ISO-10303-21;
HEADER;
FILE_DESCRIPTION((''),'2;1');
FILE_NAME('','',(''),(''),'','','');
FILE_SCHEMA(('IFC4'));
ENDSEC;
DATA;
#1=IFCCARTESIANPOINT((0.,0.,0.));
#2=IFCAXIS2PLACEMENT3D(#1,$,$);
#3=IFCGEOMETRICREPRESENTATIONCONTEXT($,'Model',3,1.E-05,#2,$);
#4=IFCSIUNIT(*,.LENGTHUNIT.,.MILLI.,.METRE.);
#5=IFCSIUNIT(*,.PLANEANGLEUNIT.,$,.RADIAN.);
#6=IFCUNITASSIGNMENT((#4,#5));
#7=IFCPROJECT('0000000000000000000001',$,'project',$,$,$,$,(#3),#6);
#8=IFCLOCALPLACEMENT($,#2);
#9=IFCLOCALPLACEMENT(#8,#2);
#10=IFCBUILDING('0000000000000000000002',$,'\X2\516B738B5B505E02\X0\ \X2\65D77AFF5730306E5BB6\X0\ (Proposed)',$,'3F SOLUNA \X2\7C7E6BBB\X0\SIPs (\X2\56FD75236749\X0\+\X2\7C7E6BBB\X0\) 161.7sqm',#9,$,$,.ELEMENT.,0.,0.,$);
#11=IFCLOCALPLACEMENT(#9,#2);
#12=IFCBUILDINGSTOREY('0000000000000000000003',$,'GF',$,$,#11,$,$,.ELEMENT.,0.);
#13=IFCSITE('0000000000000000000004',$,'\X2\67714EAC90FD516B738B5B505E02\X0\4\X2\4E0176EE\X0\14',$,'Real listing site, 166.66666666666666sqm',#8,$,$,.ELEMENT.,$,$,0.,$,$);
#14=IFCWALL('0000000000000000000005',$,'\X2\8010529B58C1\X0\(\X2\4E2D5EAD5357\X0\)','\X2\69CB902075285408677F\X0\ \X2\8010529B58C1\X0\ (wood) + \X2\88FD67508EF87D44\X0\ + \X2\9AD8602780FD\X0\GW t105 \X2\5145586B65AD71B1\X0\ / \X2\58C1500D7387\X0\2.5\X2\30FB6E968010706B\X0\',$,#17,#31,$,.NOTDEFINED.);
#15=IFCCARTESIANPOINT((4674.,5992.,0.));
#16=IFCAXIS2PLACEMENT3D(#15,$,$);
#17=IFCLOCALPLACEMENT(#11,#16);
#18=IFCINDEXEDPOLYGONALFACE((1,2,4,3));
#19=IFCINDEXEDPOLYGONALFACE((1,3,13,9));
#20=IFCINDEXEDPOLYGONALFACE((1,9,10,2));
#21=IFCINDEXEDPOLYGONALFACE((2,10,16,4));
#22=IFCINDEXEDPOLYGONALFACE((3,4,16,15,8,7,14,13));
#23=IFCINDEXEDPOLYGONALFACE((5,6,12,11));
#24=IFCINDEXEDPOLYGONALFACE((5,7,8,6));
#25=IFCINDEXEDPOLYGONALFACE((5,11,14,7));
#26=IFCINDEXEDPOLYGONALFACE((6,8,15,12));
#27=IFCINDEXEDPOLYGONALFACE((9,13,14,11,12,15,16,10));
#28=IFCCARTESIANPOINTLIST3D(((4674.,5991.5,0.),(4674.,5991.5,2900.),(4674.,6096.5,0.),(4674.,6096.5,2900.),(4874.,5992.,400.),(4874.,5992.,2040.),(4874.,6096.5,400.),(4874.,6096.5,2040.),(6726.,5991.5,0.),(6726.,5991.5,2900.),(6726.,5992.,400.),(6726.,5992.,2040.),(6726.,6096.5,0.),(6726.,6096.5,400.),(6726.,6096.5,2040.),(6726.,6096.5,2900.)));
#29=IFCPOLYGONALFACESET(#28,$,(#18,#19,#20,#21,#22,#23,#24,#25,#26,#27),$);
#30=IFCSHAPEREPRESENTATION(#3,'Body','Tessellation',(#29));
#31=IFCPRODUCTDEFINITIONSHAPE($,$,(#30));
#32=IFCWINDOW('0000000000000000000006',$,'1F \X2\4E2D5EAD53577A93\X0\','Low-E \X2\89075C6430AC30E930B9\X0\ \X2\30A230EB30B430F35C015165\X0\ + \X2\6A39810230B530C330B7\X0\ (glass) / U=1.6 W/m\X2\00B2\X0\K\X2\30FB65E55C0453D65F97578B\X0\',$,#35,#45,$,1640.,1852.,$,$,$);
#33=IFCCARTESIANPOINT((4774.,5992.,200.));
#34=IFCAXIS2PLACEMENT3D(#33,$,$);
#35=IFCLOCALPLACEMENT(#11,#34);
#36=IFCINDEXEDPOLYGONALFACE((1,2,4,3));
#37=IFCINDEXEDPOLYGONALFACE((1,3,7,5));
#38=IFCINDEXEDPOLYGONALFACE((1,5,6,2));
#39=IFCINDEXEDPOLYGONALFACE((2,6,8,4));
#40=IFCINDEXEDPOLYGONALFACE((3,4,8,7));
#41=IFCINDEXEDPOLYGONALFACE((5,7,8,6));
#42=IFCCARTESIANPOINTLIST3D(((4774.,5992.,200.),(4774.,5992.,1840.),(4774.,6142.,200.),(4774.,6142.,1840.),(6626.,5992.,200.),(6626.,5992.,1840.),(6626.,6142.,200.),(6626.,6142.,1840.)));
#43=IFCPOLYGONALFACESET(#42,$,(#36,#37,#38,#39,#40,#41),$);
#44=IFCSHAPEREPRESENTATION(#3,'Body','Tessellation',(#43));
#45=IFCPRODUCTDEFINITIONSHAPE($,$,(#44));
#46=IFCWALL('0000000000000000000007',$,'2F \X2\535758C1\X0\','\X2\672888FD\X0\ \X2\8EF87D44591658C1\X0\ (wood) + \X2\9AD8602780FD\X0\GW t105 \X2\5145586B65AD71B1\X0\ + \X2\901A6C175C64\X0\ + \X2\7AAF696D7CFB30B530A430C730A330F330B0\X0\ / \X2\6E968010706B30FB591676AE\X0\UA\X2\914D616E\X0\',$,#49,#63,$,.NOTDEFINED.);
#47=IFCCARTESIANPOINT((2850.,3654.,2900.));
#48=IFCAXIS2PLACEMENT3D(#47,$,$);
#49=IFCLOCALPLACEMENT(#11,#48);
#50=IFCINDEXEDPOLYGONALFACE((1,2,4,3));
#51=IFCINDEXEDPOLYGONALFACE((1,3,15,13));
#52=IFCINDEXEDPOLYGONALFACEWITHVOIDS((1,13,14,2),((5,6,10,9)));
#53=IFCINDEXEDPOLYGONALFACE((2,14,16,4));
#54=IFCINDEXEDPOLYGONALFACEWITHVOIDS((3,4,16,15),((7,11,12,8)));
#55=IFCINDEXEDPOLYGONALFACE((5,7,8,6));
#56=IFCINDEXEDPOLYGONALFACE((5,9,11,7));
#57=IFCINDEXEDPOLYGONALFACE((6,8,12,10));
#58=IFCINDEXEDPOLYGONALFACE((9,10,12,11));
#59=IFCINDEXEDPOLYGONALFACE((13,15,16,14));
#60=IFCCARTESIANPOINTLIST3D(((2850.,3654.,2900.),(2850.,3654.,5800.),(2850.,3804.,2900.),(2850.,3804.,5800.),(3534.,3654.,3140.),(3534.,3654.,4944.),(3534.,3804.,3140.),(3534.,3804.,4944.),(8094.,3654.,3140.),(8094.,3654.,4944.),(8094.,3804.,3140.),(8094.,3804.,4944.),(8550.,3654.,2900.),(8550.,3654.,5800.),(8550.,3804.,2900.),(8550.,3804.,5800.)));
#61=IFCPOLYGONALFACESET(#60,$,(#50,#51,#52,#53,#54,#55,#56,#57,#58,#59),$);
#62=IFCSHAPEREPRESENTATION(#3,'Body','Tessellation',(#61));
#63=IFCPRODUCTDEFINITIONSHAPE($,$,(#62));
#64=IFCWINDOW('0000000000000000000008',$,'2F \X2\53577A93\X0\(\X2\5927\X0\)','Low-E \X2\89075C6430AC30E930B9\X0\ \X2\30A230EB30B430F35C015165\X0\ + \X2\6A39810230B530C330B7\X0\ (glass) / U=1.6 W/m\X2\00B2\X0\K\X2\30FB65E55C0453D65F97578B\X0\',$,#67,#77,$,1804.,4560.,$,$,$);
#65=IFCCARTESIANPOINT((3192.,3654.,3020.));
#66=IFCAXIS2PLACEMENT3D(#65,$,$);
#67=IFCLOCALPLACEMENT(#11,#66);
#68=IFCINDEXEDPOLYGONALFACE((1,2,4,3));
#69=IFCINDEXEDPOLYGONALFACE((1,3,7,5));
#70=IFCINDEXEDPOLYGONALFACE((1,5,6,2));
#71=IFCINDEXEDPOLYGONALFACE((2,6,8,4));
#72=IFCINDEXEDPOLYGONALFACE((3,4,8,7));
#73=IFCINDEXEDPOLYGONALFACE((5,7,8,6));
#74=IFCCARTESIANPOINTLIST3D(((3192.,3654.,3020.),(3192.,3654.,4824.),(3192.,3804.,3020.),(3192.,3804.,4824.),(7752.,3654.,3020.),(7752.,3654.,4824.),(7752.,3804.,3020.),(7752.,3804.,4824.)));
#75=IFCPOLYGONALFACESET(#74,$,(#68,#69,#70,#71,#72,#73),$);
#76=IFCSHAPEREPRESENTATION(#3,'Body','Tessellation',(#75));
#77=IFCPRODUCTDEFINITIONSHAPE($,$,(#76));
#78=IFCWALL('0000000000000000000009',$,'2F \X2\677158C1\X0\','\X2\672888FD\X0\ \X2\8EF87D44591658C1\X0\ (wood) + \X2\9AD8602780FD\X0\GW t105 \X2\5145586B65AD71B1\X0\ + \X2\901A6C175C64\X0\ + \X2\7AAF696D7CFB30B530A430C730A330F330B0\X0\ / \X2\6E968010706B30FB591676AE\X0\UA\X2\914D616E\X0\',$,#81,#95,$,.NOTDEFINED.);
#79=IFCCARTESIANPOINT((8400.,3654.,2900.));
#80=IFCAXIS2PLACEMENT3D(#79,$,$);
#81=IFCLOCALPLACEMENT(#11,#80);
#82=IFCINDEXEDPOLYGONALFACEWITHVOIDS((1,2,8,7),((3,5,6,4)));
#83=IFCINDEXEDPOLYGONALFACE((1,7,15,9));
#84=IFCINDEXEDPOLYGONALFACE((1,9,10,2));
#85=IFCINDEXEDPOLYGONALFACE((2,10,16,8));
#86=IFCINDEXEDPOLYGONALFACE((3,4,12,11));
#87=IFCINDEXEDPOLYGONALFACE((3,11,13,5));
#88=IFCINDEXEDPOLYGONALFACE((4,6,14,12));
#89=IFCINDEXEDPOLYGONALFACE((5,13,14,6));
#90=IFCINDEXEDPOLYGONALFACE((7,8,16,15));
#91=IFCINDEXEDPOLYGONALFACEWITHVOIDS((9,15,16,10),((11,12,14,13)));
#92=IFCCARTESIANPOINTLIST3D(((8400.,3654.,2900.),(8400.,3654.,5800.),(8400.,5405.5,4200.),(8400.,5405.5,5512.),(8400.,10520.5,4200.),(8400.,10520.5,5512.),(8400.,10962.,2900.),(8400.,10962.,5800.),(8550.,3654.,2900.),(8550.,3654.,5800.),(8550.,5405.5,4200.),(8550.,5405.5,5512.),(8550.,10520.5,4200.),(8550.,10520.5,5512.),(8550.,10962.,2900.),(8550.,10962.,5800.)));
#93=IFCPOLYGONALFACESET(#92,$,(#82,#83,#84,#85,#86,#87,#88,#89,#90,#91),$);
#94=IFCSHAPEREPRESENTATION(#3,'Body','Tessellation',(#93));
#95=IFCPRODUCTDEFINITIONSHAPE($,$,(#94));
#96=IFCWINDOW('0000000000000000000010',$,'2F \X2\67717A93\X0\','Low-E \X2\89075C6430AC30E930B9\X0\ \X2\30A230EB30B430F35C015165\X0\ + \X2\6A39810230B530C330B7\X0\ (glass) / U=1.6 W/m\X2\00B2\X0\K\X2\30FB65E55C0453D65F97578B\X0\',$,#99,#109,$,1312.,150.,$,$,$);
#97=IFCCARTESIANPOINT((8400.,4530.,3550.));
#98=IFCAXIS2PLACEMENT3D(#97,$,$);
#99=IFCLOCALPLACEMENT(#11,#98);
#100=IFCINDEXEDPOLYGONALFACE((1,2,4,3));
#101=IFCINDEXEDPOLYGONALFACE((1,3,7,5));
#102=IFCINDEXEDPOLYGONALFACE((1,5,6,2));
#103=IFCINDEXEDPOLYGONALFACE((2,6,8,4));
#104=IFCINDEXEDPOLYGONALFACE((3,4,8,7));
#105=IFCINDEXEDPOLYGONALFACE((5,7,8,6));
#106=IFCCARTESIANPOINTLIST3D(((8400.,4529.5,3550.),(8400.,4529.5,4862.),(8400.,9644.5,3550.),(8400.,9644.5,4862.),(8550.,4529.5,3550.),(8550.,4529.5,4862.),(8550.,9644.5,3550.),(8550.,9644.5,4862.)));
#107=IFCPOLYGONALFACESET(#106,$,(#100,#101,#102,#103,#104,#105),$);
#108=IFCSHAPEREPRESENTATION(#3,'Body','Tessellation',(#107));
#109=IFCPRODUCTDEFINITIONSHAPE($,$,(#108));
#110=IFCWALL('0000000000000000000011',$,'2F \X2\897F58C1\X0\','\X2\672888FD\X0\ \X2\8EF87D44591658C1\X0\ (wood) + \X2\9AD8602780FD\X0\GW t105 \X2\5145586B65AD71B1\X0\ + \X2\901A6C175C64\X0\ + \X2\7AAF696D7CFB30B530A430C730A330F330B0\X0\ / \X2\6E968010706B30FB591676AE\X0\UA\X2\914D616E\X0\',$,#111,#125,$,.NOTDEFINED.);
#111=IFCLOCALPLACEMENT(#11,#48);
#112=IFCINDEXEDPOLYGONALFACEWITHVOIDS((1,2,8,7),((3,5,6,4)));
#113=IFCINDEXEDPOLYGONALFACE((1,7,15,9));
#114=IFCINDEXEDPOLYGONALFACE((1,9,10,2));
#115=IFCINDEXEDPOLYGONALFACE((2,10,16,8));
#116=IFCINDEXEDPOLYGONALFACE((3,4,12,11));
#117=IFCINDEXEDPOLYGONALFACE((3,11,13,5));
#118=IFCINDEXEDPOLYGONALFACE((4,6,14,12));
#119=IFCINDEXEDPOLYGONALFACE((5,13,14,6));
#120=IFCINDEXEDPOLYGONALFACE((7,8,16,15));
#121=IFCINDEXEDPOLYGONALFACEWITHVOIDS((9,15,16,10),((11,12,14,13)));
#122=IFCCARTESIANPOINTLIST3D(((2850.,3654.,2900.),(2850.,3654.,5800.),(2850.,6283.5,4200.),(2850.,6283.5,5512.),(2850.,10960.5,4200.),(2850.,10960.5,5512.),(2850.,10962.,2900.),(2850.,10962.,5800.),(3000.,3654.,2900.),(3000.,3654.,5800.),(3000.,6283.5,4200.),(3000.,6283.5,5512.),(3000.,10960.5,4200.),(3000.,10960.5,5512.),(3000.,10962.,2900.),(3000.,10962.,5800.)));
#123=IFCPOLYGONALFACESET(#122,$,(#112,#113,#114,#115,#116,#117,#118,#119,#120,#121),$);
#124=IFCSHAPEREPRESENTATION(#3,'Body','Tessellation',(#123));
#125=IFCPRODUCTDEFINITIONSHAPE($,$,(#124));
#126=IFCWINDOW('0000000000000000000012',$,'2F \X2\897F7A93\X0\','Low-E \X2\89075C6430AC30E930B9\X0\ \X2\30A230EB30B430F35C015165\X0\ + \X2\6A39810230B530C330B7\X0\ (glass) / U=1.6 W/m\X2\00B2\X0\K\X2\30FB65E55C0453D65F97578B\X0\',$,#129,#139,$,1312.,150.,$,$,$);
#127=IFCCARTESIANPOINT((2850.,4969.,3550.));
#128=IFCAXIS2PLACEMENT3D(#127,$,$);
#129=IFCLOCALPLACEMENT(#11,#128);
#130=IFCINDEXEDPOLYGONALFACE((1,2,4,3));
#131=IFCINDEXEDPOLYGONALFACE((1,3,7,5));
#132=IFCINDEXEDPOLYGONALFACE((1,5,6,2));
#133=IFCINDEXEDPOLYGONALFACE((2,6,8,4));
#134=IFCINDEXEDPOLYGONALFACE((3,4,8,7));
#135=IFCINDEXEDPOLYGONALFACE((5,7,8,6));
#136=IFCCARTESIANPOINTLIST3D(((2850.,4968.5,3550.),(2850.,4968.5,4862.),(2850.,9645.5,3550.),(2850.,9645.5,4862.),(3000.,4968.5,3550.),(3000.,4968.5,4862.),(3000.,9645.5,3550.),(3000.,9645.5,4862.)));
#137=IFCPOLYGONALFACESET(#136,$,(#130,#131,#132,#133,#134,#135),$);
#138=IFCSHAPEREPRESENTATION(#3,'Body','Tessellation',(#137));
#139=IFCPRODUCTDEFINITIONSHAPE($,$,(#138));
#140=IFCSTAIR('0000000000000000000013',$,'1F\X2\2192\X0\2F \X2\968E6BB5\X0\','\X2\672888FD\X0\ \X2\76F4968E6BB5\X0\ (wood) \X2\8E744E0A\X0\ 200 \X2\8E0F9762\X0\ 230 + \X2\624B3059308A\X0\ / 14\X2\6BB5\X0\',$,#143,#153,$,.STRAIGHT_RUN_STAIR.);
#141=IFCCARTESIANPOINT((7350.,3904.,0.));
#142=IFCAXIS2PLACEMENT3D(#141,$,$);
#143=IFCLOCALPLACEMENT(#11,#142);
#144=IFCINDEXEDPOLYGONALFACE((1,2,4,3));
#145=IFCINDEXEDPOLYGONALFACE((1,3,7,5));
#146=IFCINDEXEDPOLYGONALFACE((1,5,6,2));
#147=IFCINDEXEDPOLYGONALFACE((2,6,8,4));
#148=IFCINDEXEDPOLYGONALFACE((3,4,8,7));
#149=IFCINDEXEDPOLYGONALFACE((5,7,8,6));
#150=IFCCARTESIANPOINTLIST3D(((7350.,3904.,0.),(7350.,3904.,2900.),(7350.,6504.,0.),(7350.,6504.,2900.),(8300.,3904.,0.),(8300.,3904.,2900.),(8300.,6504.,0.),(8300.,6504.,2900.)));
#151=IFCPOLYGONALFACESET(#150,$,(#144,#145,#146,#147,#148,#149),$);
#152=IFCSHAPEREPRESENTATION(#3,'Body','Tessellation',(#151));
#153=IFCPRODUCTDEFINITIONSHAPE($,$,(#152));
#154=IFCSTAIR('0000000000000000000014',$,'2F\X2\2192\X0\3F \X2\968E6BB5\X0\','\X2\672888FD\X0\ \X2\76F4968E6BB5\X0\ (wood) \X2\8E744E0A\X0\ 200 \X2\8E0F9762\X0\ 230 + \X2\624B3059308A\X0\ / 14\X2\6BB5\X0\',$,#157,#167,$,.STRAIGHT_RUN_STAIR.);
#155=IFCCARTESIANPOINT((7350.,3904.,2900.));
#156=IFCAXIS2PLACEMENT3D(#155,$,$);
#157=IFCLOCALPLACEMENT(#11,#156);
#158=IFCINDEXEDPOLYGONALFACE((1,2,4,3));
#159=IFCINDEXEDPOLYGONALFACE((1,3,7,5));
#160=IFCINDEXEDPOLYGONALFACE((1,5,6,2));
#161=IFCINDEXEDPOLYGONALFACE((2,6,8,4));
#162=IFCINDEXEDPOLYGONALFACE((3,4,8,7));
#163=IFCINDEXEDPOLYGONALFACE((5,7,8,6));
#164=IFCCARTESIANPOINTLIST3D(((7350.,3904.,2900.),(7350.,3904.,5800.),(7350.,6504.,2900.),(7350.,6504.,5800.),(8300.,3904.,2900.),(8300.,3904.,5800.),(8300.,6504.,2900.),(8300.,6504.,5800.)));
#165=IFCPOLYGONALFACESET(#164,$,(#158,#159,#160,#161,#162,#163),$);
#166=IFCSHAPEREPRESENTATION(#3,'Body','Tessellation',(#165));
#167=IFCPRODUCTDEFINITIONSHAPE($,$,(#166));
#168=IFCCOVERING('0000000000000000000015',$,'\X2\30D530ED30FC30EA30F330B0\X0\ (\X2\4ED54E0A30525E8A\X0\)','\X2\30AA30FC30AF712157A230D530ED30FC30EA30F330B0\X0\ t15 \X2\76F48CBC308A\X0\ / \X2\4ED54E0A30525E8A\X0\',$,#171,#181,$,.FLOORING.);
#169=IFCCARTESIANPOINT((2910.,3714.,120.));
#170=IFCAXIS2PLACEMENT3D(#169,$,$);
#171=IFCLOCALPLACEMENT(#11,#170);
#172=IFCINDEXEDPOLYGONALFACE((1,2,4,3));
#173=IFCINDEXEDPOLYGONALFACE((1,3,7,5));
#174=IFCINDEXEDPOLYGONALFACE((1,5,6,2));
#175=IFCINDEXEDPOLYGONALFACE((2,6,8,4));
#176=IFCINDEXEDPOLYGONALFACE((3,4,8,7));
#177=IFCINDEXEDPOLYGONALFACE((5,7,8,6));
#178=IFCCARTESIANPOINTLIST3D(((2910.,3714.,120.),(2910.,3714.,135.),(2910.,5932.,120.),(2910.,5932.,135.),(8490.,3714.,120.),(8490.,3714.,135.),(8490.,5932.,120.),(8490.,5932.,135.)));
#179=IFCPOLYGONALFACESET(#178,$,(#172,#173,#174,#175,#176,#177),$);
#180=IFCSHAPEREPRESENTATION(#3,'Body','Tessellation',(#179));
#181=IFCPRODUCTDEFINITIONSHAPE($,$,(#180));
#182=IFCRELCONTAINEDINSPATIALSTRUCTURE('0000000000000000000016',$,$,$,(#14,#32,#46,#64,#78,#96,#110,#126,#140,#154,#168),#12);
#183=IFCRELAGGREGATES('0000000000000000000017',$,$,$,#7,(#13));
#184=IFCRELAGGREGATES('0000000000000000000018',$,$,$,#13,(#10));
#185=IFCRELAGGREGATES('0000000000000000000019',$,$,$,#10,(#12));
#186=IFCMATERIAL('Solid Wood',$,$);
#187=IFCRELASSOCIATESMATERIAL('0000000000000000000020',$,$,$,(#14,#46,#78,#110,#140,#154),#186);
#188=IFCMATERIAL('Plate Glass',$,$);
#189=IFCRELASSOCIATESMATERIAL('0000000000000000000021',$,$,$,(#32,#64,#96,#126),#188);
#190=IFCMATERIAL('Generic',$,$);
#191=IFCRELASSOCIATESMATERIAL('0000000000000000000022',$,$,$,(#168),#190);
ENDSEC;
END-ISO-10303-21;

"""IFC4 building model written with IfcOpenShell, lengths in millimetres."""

from ifc_helpers import new_model, si_unit, frame, frame_2d, origin, place, context, project, spatial, rectangle, extrude, material, element, fill, save


model = new_model("IFC4")

# Units and contexts
model_context = context("Model", 3, precision=1e-05, world=origin())
ifc_project = project(units=[si_unit("LENGTHUNIT", "METRE", prefix="MILLI"), si_unit("PLANEANGLEUNIT", "RADIAN")], contexts=[model_context])

# Site, building, storey
site_placement = place(None, origin())
site = spatial("IfcSite", under=ifc_project, at=site_placement, Name="東京都八王子市4丁目14", ObjectType="Real listing site, 166.66666666666666sqm", CompositionType="ELEMENT", RefElevation=0.0)
building_placement = place(site_placement, origin())
building = spatial("IfcBuilding", under=site, at=building_placement, Name="八王子市 旗竿地の家 (Proposed)", ObjectType="3F SOLUNA 籾殻SIPs (国産杉+籾殻) 161.7sqm", CompositionType="ELEMENT", ElevationOfRefHeight=0.0, ElevationOfTerrain=0.0)
storey_placement = place(building_placement, origin())
storey = spatial("IfcBuildingStorey", under=building, at=storey_placement, Name="GF", CompositionType="ELEMENT", Elevation=0.0)

# Shared definitions
ifc_material_1 = material(Name="Solid Wood")
ifc_material_2 = material(Name="Generic")

# Shared definitions
ifc_material_3 = material(Name="Plate Glass")

# Walls, openings, windows
wall_1_placement = place(storey_placement, frame((4674.0, 5992.0, 0.0)))
wall_1 = element("IfcWall", 1, at=wall_1_placement, inside=storey, material=ifc_material_1, Name="耐力壁(中庭南)", Description="構造用合板 耐力壁 (wood) + 製材軸組 + 高性能GW t105 充填断熱 / 壁倍率2.5・準耐火", PredefinedType="NOTDEFINED", context=model_context, shape_type="SweptSolid", body=[
    extrude(rectangle(XDim=2052.0, YDim=105.0, at=frame_2d((1026.0, 52.0))), frame((4674.0, 5992.0, 0.0)), (0.0, 0.0, 1.0), 2900.0),
])
opening_1_placement = place(storey_placement, frame((4774.0, 5992.0, 200.0)))
opening_1 = element("IfcOpeningElement", 2, at=opening_1_placement, cuts=wall_1, PredefinedType="NOTDEFINED", context=model_context, shape_type="SweptSolid", body=[
    extrude(rectangle(XDim=1852.0, YDim=150.0, at=frame_2d((926.0, 75.0))), frame((4774.0, 5992.0, 200.0)), (0.0, 0.0, 1.0), 1640.0),
])
window_1_placement = place(storey_placement, frame((4774.0, 5992.0, 200.0)))
window_1 = element("IfcWindow", 3, at=window_1_placement, inside=storey, material=ifc_material_3, Name="1F 中庭南窓", Description="Low-E 複層ガラス アルゴン封入 + 樹脂サッシ (glass) / U=1.6 W/m²K・日射取得型", OverallHeight=1640.0, OverallWidth=1852.0, context=model_context, shape_type="SweptSolid", body=[
    extrude(rectangle(XDim=1852.0, YDim=150.0, at=frame_2d((926.0, 75.0))), frame((4774.0, 5992.0, 200.0)), (0.0, 0.0, 1.0), 1640.0),
])
fill(opening_1, window_1)
wall_2_placement = place(storey_placement, frame((2850.0, 3654.0, 2900.0)))
wall_2 = element("IfcWall", 4, at=wall_2_placement, inside=storey, material=ifc_material_1, Name="2F 南壁", Description="木製 軸組外壁 (wood) + 高性能GW t105 充填断熱 + 通気層 + 窯業系サイディング / 準耐火・外皮UA配慮", PredefinedType="NOTDEFINED", context=model_context, shape_type="SweptSolid", body=[
    extrude(rectangle(XDim=5700.0, YDim=150.0, at=frame_2d((2850.0, 75.0))), frame((2850.0, 3654.0, 2900.0)), (0.0, 0.0, 1.0), 2900.0),
])
opening_2_placement = place(storey_placement, frame((3192.0, 3654.0, 3020.0)))
opening_2 = element("IfcOpeningElement", 5, at=opening_2_placement, cuts=wall_2, PredefinedType="NOTDEFINED", context=model_context, shape_type="SweptSolid", body=[
    extrude(rectangle(XDim=4560.0, YDim=150.0, at=frame_2d((2280.0, 75.0))), frame((3192.0, 3654.0, 3020.0)), (0.0, 0.0, 1.0), 1804.0),
])
window_2_placement = place(storey_placement, frame((3192.0, 3654.0, 3020.0)))
window_2 = element("IfcWindow", 6, at=window_2_placement, inside=storey, material=ifc_material_3, Name="2F 南窓(大)", Description="Low-E 複層ガラス アルゴン封入 + 樹脂サッシ (glass) / U=1.6 W/m²K・日射取得型", OverallHeight=1804.0, OverallWidth=4560.0, context=model_context, shape_type="SweptSolid", body=[
    extrude(rectangle(XDim=4560.0, YDim=150.0, at=frame_2d((2280.0, 75.0))), frame((3192.0, 3654.0, 3020.0)), (0.0, 0.0, 1.0), 1804.0),
])
fill(opening_2, window_2)
wall_3_placement = place(storey_placement, frame((8400.0, 3654.0, 2900.0)))
wall_3 = element("IfcWall", 7, at=wall_3_placement, inside=storey, material=ifc_material_1, Name="2F 東壁", Description="木製 軸組外壁 (wood) + 高性能GW t105 充填断熱 + 通気層 + 窯業系サイディング / 準耐火・外皮UA配慮", PredefinedType="NOTDEFINED", context=model_context, shape_type="SweptSolid", body=[
    extrude(rectangle(XDim=150.0, YDim=7308.0, at=frame_2d((75.0, 3654.0))), frame((8400.0, 3654.0, 2900.0)), (0.0, 0.0, 1.0), 2900.0),
])
opening_3_placement = place(storey_placement, frame((8400.0, 4530.0, 3550.0)))
opening_3 = element("IfcOpeningElement", 8, at=opening_3_placement, cuts=wall_3, PredefinedType="NOTDEFINED", context=model_context, shape_type="SweptSolid", body=[
    extrude(rectangle(XDim=150.0, YDim=5115.0, at=frame_2d((75.0, 2557.0))), frame((8400.0, 4530.0, 3550.0)), (0.0, 0.0, 1.0), 1312.0),
])
window_3_placement = place(storey_placement, frame((8400.0, 4530.0, 3550.0)))
window_3 = element("IfcWindow", 9, at=window_3_placement, inside=storey, material=ifc_material_3, Name="2F 東窓", Description="Low-E 複層ガラス アルゴン封入 + 樹脂サッシ (glass) / U=1.6 W/m²K・日射取得型", OverallHeight=1312.0, OverallWidth=150.0, context=model_context, shape_type="SweptSolid", body=[
    extrude(rectangle(XDim=150.0, YDim=5115.0, at=frame_2d((75.0, 2557.0))), frame((8400.0, 4530.0, 3550.0)), (0.0, 0.0, 1.0), 1312.0),
])
fill(opening_3, window_3)
wall_4_placement = place(storey_placement, frame((2850.0, 3654.0, 2900.0)))
wall_4 = element("IfcWall", 10, at=wall_4_placement, inside=storey, material=ifc_material_1, Name="2F 西壁", Description="木製 軸組外壁 (wood) + 高性能GW t105 充填断熱 + 通気層 + 窯業系サイディング / 準耐火・外皮UA配慮", PredefinedType="NOTDEFINED", context=model_context, shape_type="SweptSolid", body=[
    extrude(rectangle(XDim=150.0, YDim=7308.0, at=frame_2d((75.0, 3654.0))), frame((2850.0, 3654.0, 2900.0)), (0.0, 0.0, 1.0), 2900.0),
])
opening_4_placement = place(storey_placement, frame((2850.0, 4969.0, 3550.0)))
opening_4 = element("IfcOpeningElement", 11, at=opening_4_placement, cuts=wall_4, PredefinedType="NOTDEFINED", context=model_context, shape_type="SweptSolid", body=[
    extrude(rectangle(XDim=150.0, YDim=4677.0, at=frame_2d((75.0, 2338.0))), frame((2850.0, 4969.0, 3550.0)), (0.0, 0.0, 1.0), 1312.0),
])
window_4_placement = place(storey_placement, frame((2850.0, 4969.0, 3550.0)))
window_4 = element("IfcWindow", 12, at=window_4_placement, inside=storey, material=ifc_material_3, Name="2F 西窓", Description="Low-E 複層ガラス アルゴン封入 + 樹脂サッシ (glass) / U=1.6 W/m²K・日射取得型", OverallHeight=1312.0, OverallWidth=150.0, context=model_context, shape_type="SweptSolid", body=[
    extrude(rectangle(XDim=150.0, YDim=4677.0, at=frame_2d((75.0, 2338.0))), frame((2850.0, 4969.0, 3550.0)), (0.0, 0.0, 1.0), 1312.0),
])
fill(opening_4, window_4)

# Stairs
stair_1_placement = place(storey_placement, frame((7350.0, 3904.0, 0.0)))
element("IfcStair", 13, at=stair_1_placement, inside=storey, material=ifc_material_1, Name="1F→2F 階段", Description="木製 直階段 (wood) 蹴上 200 踏面 230 + 手すり / 14段", PredefinedType="STRAIGHT_RUN_STAIR", context=model_context, shape_type="SweptSolid", body=[
    extrude(rectangle(XDim=950.0, YDim=2600.0, at=frame_2d((475.0, 1300.0))), frame((7350.0, 3904.0, 0.0)), (0.0, 0.0, 1.0), 2900.0),
])
stair_2_placement = place(storey_placement, frame((7350.0, 3904.0, 2900.0)))
element("IfcStair", 14, at=stair_2_placement, inside=storey, material=ifc_material_1, Name="2F→3F 階段", Description="木製 直階段 (wood) 蹴上 200 踏面 230 + 手すり / 14段", PredefinedType="STRAIGHT_RUN_STAIR", context=model_context, shape_type="SweptSolid", body=[
    extrude(rectangle(XDim=950.0, YDim=2600.0, at=frame_2d((475.0, 1300.0))), frame((7350.0, 3904.0, 2900.0)), (0.0, 0.0, 1.0), 2900.0),
])

# Covering
covering_placement = place(storey_placement, frame((2910.0, 3714.0, 120.0)))
element("IfcCovering", 15, at=covering_placement, inside=storey, material=ifc_material_2, Name="フローリング (仕上げ床)", Description="オーク無垢フローリング t15 直貼り / 仕上げ床", PredefinedType="FLOORING", context=model_context, shape_type="SweptSolid", body=[
    extrude(rectangle(XDim=5580.0, YDim=2218.0, at=frame_2d((2790.0, 1109.0))), frame((2910.0, 3714.0, 120.0)), (0.0, 0.0, 1.0), 15.0),
])

save(model, "model.ifc")
